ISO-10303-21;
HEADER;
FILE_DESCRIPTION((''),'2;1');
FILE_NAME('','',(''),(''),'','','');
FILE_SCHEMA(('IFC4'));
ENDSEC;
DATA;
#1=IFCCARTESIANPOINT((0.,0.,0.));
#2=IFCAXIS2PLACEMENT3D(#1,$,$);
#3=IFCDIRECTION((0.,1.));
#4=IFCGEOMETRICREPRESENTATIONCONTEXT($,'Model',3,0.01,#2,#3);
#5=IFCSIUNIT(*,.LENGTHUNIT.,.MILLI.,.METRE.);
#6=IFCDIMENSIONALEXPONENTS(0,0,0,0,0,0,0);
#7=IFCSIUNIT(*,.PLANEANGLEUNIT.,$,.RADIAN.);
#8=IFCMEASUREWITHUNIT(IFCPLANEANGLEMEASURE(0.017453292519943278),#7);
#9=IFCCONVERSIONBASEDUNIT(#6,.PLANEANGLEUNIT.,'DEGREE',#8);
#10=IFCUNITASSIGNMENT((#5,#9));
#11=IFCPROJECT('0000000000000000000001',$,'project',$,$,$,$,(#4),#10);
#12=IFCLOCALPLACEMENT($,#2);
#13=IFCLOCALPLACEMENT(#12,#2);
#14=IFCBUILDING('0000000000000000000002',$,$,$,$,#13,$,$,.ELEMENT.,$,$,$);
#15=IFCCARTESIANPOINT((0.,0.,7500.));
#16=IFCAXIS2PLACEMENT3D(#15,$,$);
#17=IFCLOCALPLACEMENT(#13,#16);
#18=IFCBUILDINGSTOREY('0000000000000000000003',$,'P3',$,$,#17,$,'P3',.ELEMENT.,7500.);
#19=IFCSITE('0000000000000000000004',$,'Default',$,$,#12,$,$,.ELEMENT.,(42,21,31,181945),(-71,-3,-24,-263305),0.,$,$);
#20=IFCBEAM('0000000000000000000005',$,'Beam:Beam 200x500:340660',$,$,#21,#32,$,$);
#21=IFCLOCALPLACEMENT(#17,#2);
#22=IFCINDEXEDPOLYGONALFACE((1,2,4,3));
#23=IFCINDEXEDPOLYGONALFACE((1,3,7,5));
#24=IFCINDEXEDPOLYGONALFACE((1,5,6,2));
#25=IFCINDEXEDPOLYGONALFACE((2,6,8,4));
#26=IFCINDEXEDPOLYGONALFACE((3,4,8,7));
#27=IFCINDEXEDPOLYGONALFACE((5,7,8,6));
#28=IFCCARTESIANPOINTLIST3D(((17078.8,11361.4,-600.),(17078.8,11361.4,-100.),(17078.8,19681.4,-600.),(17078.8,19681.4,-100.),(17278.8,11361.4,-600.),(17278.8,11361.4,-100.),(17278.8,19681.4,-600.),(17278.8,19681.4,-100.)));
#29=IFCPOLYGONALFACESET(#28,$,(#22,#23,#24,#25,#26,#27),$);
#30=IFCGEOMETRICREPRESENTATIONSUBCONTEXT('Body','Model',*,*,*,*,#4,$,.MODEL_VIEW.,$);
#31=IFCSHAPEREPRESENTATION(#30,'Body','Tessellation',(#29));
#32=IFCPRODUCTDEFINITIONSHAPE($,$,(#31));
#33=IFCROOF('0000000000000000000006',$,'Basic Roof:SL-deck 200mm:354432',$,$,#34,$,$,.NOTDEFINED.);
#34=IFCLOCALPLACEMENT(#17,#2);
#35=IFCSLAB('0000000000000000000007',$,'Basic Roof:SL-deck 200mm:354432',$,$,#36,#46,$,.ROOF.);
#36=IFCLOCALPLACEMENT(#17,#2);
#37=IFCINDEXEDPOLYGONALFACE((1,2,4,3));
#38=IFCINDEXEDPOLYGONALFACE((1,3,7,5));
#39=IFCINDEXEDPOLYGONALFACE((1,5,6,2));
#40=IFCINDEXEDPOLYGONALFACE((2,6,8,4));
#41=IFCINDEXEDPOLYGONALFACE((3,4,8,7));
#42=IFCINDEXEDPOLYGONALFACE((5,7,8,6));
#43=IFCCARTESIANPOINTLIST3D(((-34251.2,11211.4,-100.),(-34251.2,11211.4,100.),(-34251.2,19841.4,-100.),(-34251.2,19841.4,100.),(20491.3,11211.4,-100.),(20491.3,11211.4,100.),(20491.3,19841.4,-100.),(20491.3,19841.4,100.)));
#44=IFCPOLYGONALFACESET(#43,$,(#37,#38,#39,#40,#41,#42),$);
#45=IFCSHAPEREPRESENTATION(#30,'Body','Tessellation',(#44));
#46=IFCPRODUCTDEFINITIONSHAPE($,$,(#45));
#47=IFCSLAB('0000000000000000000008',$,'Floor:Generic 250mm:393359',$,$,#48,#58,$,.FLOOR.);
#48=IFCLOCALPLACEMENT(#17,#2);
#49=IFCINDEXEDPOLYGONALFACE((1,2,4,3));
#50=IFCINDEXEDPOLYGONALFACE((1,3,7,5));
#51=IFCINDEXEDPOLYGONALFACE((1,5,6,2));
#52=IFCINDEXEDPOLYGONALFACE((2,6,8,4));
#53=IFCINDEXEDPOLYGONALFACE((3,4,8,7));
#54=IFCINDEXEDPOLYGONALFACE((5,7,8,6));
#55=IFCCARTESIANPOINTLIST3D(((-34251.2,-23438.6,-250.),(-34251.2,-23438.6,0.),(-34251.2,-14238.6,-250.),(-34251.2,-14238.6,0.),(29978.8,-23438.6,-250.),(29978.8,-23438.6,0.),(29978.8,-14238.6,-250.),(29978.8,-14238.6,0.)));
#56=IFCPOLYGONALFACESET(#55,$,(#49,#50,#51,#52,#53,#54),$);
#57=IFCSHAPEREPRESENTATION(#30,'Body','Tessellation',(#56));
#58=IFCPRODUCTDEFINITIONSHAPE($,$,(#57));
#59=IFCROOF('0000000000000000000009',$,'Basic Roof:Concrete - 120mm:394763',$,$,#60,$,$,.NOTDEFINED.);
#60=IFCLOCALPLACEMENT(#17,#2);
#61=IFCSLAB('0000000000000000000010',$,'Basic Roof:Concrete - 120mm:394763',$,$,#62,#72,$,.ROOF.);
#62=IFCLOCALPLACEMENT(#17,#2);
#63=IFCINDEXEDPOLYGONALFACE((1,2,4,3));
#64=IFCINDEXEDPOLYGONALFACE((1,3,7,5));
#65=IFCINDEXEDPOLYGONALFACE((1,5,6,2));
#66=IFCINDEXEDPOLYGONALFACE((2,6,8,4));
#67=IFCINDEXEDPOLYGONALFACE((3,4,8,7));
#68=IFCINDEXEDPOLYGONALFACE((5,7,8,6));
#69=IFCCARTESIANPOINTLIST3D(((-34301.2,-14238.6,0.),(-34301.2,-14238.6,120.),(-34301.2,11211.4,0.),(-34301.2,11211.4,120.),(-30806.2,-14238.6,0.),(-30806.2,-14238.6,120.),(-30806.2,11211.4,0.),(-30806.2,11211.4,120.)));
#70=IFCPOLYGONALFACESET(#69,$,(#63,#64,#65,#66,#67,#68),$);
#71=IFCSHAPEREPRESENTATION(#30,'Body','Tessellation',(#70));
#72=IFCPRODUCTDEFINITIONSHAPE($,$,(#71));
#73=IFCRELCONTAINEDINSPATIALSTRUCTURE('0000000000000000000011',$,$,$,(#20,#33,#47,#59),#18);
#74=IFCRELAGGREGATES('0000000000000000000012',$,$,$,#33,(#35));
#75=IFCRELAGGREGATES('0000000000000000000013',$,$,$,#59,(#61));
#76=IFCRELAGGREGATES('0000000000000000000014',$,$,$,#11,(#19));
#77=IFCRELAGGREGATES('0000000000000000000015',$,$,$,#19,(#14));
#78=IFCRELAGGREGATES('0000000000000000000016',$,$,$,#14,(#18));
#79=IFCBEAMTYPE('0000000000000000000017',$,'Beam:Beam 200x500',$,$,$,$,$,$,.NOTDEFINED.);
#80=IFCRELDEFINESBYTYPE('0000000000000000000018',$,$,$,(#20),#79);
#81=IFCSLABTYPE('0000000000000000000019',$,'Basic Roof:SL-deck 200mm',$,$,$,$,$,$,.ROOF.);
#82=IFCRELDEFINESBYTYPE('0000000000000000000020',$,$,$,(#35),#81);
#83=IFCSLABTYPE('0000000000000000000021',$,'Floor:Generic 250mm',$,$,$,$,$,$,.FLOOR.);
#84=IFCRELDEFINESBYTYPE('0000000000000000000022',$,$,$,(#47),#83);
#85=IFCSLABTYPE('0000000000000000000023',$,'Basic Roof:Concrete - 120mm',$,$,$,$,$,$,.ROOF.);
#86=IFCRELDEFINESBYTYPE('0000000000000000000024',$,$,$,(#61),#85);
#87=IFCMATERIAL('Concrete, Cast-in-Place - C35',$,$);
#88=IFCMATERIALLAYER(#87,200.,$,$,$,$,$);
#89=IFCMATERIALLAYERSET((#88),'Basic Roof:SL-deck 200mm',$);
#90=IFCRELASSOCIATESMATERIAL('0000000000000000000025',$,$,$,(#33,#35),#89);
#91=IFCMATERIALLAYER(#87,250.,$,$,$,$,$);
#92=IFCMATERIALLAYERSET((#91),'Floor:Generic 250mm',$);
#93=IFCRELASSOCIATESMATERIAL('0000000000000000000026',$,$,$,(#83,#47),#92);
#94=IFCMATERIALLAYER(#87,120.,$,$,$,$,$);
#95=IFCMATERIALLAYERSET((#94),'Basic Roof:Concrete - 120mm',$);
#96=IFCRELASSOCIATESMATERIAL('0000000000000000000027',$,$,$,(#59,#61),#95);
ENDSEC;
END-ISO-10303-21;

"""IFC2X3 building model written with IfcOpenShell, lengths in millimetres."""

from ifc_helpers import new_model, entity, si_unit, converted_unit, direction, frame, frame_2d, origin, origin_2d_with_axis, place, context, subcontext, project, spatial, rectangle, extrude, material, layer, layer_set, layer_usage, type_object, element, aggregate, save


model = new_model("IFC2X3")

# Units and contexts
model_context = context("Model", 3, precision=0.01, world=origin(), true_north=direction((0.0, 1.0)))
body_context = subcontext(model_context, "Body", "Model", "MODEL_VIEW")
ifc_project = project(units=[si_unit("LENGTHUNIT", "METRE", prefix="MILLI"), converted_unit("PLANEANGLEUNIT", "DEGREE", entity("IfcPlaneAngleMeasure", 0.017453292519943278), si_unit("PLANEANGLEUNIT", "RADIAN"), dimensions=[0, 0, 0, 0, 0, 0, 0])], contexts=[model_context])

# Site, building, storey
site_placement = place(None, origin())
site = spatial("IfcSite", under=ifc_project, at=site_placement, Name="Default", CompositionType="ELEMENT", RefLatitude=(42, 21, 31, 181945), RefLongitude=(-71, -3, -24, -263305), RefElevation=0.0)
building_placement = place(site_placement, origin())
building = spatial("IfcBuilding", under=site, at=building_placement, CompositionType="ELEMENT")
storey_placement = place(building_placement, frame((0.0, 0.0, 7500.0)))
storey = spatial("IfcBuildingStorey", under=building, at=storey_placement, Name="P3", LongName="P3", CompositionType="ELEMENT", Elevation=7500.0)

# Shared definitions
ifc_material_1 = material(Name="Concrete, Cast-in-Place - C35")

# Beam
beam_type_1 = type_object("IfcBeamType", Name="Beam:Beam 200x500", PredefinedType="NOTDEFINED")
for number, where, z_axis, x_axis, name in (
    (1, (17153.8, 19681.4, -100.0), (0.0, 0.0, 1.0), (0.0, -1.0, 0.0), "Beam:Beam 200x500:340660"),
):
    element("IfcBeam", number, at=place(storey_placement, frame(where, z_axis=z_axis, x_axis=x_axis)), inside=storey, type_object=beam_type_1, Name=name, context=body_context, shape_type="SweptSolid", body=[
        extrude(rectangle(XDim=500.0, YDim=200.0, at=frame_2d((0.0, 0.0), x_axis=(1.0, 0.0))), frame((0.0, 25.0, -250.0), z_axis=(1.0, 0.0, 0.0), x_axis=(0.0, 0.0, -1.0)), (0.0, 0.0, 1.0), 8320.0),
    ])

# Roof, slab
ifc_layer_1 = layer(ifc_material_1, 200.0)
ifc_layer_set_1 = layer_set([ifc_layer_1], Name="Basic Roof:SL-deck 200mm")
roof_1_placement = place(storey_placement, frame((-34251.2, 11211.4, -100.0)))
roof_1 = element("IfcRoof", 2, at=roof_1_placement, inside=storey, material=ifc_layer_set_1, Name="Basic Roof:SL-deck 200mm:354432", ShapeType="NOTDEFINED")
slab_type_1 = type_object("IfcSlabType", Name="Basic Roof:SL-deck 200mm", PredefinedType="ROOF")
slab_1_placement = place(roof_1_placement, origin())
slab_1 = element("IfcSlab", 3, at=slab_1_placement, type_object=slab_type_1, material=ifc_layer_set_1, Name="Basic Roof:SL-deck 200mm:354432", PredefinedType="ROOF", context=body_context, shape_type="SweptSolid", body=[
    extrude(rectangle(XDim=54742.5, YDim=8630.0, at=origin_2d_with_axis()), frame((27371.3, 4315.0, 0.0)), (0.0, 0.0, 1.0), 200.0),
])
aggregate(roof_1, [slab_1])

# Slab
ifc_layer_2 = layer(ifc_material_1, 250.0)
ifc_layer_set_2 = layer_set([ifc_layer_2], Name="Floor:Generic 250mm")
ifc_layer_usage_1 = layer_usage(ifc_layer_set_2, "AXIS3", "POSITIVE", 0.0)
slab_type_2 = type_object("IfcSlabType", Name="Floor:Generic 250mm", PredefinedType="FLOOR", material=ifc_layer_set_2)
slab_2_placement = place(storey_placement, origin())
element("IfcSlab", 4, at=slab_2_placement, inside=storey, type_object=slab_type_2, material=ifc_layer_usage_1, Name="Floor:Generic 250mm:393359", PredefinedType="FLOOR", context=body_context, shape_type="SweptSolid", body=[
    extrude(rectangle(XDim=9200.0, YDim=64230.0, at=origin_2d_with_axis()), frame((-2136.2, -18838.6, 0.0), z_axis=(0.0, 0.0, -1.0), x_axis=(0.0, 1.0, 0.0)), (0.0, 0.0, 1.0), 250.0),
])

# Roof, slab
ifc_layer_3 = layer(ifc_material_1, 120.0)
ifc_layer_set_3 = layer_set([ifc_layer_3], Name="Basic Roof:Concrete - 120mm")
roof_2_placement = place(storey_placement, frame((-34301.2, -14238.6, 0.0)))
roof_2 = element("IfcRoof", 5, at=roof_2_placement, inside=storey, material=ifc_layer_set_3, Name="Basic Roof:Concrete - 120mm:394763", ShapeType="NOTDEFINED")
slab_type_3 = type_object("IfcSlabType", Name="Basic Roof:Concrete - 120mm", PredefinedType="ROOF")
slab_3_placement = place(roof_2_placement, origin())
slab_3 = element("IfcSlab", 6, at=slab_3_placement, type_object=slab_type_3, material=ifc_layer_set_3, Name="Basic Roof:Concrete - 120mm:394763", PredefinedType="ROOF", context=body_context, shape_type="SweptSolid", body=[
    extrude(rectangle(XDim=3495.0, YDim=25450.0, at=origin_2d_with_axis()), frame((1747.5, 12725.0, 0.0)), (0.0, 0.0, 1.0), 120.0),
])
aggregate(roof_2, [slab_3])

save(model, "model.ifc")
